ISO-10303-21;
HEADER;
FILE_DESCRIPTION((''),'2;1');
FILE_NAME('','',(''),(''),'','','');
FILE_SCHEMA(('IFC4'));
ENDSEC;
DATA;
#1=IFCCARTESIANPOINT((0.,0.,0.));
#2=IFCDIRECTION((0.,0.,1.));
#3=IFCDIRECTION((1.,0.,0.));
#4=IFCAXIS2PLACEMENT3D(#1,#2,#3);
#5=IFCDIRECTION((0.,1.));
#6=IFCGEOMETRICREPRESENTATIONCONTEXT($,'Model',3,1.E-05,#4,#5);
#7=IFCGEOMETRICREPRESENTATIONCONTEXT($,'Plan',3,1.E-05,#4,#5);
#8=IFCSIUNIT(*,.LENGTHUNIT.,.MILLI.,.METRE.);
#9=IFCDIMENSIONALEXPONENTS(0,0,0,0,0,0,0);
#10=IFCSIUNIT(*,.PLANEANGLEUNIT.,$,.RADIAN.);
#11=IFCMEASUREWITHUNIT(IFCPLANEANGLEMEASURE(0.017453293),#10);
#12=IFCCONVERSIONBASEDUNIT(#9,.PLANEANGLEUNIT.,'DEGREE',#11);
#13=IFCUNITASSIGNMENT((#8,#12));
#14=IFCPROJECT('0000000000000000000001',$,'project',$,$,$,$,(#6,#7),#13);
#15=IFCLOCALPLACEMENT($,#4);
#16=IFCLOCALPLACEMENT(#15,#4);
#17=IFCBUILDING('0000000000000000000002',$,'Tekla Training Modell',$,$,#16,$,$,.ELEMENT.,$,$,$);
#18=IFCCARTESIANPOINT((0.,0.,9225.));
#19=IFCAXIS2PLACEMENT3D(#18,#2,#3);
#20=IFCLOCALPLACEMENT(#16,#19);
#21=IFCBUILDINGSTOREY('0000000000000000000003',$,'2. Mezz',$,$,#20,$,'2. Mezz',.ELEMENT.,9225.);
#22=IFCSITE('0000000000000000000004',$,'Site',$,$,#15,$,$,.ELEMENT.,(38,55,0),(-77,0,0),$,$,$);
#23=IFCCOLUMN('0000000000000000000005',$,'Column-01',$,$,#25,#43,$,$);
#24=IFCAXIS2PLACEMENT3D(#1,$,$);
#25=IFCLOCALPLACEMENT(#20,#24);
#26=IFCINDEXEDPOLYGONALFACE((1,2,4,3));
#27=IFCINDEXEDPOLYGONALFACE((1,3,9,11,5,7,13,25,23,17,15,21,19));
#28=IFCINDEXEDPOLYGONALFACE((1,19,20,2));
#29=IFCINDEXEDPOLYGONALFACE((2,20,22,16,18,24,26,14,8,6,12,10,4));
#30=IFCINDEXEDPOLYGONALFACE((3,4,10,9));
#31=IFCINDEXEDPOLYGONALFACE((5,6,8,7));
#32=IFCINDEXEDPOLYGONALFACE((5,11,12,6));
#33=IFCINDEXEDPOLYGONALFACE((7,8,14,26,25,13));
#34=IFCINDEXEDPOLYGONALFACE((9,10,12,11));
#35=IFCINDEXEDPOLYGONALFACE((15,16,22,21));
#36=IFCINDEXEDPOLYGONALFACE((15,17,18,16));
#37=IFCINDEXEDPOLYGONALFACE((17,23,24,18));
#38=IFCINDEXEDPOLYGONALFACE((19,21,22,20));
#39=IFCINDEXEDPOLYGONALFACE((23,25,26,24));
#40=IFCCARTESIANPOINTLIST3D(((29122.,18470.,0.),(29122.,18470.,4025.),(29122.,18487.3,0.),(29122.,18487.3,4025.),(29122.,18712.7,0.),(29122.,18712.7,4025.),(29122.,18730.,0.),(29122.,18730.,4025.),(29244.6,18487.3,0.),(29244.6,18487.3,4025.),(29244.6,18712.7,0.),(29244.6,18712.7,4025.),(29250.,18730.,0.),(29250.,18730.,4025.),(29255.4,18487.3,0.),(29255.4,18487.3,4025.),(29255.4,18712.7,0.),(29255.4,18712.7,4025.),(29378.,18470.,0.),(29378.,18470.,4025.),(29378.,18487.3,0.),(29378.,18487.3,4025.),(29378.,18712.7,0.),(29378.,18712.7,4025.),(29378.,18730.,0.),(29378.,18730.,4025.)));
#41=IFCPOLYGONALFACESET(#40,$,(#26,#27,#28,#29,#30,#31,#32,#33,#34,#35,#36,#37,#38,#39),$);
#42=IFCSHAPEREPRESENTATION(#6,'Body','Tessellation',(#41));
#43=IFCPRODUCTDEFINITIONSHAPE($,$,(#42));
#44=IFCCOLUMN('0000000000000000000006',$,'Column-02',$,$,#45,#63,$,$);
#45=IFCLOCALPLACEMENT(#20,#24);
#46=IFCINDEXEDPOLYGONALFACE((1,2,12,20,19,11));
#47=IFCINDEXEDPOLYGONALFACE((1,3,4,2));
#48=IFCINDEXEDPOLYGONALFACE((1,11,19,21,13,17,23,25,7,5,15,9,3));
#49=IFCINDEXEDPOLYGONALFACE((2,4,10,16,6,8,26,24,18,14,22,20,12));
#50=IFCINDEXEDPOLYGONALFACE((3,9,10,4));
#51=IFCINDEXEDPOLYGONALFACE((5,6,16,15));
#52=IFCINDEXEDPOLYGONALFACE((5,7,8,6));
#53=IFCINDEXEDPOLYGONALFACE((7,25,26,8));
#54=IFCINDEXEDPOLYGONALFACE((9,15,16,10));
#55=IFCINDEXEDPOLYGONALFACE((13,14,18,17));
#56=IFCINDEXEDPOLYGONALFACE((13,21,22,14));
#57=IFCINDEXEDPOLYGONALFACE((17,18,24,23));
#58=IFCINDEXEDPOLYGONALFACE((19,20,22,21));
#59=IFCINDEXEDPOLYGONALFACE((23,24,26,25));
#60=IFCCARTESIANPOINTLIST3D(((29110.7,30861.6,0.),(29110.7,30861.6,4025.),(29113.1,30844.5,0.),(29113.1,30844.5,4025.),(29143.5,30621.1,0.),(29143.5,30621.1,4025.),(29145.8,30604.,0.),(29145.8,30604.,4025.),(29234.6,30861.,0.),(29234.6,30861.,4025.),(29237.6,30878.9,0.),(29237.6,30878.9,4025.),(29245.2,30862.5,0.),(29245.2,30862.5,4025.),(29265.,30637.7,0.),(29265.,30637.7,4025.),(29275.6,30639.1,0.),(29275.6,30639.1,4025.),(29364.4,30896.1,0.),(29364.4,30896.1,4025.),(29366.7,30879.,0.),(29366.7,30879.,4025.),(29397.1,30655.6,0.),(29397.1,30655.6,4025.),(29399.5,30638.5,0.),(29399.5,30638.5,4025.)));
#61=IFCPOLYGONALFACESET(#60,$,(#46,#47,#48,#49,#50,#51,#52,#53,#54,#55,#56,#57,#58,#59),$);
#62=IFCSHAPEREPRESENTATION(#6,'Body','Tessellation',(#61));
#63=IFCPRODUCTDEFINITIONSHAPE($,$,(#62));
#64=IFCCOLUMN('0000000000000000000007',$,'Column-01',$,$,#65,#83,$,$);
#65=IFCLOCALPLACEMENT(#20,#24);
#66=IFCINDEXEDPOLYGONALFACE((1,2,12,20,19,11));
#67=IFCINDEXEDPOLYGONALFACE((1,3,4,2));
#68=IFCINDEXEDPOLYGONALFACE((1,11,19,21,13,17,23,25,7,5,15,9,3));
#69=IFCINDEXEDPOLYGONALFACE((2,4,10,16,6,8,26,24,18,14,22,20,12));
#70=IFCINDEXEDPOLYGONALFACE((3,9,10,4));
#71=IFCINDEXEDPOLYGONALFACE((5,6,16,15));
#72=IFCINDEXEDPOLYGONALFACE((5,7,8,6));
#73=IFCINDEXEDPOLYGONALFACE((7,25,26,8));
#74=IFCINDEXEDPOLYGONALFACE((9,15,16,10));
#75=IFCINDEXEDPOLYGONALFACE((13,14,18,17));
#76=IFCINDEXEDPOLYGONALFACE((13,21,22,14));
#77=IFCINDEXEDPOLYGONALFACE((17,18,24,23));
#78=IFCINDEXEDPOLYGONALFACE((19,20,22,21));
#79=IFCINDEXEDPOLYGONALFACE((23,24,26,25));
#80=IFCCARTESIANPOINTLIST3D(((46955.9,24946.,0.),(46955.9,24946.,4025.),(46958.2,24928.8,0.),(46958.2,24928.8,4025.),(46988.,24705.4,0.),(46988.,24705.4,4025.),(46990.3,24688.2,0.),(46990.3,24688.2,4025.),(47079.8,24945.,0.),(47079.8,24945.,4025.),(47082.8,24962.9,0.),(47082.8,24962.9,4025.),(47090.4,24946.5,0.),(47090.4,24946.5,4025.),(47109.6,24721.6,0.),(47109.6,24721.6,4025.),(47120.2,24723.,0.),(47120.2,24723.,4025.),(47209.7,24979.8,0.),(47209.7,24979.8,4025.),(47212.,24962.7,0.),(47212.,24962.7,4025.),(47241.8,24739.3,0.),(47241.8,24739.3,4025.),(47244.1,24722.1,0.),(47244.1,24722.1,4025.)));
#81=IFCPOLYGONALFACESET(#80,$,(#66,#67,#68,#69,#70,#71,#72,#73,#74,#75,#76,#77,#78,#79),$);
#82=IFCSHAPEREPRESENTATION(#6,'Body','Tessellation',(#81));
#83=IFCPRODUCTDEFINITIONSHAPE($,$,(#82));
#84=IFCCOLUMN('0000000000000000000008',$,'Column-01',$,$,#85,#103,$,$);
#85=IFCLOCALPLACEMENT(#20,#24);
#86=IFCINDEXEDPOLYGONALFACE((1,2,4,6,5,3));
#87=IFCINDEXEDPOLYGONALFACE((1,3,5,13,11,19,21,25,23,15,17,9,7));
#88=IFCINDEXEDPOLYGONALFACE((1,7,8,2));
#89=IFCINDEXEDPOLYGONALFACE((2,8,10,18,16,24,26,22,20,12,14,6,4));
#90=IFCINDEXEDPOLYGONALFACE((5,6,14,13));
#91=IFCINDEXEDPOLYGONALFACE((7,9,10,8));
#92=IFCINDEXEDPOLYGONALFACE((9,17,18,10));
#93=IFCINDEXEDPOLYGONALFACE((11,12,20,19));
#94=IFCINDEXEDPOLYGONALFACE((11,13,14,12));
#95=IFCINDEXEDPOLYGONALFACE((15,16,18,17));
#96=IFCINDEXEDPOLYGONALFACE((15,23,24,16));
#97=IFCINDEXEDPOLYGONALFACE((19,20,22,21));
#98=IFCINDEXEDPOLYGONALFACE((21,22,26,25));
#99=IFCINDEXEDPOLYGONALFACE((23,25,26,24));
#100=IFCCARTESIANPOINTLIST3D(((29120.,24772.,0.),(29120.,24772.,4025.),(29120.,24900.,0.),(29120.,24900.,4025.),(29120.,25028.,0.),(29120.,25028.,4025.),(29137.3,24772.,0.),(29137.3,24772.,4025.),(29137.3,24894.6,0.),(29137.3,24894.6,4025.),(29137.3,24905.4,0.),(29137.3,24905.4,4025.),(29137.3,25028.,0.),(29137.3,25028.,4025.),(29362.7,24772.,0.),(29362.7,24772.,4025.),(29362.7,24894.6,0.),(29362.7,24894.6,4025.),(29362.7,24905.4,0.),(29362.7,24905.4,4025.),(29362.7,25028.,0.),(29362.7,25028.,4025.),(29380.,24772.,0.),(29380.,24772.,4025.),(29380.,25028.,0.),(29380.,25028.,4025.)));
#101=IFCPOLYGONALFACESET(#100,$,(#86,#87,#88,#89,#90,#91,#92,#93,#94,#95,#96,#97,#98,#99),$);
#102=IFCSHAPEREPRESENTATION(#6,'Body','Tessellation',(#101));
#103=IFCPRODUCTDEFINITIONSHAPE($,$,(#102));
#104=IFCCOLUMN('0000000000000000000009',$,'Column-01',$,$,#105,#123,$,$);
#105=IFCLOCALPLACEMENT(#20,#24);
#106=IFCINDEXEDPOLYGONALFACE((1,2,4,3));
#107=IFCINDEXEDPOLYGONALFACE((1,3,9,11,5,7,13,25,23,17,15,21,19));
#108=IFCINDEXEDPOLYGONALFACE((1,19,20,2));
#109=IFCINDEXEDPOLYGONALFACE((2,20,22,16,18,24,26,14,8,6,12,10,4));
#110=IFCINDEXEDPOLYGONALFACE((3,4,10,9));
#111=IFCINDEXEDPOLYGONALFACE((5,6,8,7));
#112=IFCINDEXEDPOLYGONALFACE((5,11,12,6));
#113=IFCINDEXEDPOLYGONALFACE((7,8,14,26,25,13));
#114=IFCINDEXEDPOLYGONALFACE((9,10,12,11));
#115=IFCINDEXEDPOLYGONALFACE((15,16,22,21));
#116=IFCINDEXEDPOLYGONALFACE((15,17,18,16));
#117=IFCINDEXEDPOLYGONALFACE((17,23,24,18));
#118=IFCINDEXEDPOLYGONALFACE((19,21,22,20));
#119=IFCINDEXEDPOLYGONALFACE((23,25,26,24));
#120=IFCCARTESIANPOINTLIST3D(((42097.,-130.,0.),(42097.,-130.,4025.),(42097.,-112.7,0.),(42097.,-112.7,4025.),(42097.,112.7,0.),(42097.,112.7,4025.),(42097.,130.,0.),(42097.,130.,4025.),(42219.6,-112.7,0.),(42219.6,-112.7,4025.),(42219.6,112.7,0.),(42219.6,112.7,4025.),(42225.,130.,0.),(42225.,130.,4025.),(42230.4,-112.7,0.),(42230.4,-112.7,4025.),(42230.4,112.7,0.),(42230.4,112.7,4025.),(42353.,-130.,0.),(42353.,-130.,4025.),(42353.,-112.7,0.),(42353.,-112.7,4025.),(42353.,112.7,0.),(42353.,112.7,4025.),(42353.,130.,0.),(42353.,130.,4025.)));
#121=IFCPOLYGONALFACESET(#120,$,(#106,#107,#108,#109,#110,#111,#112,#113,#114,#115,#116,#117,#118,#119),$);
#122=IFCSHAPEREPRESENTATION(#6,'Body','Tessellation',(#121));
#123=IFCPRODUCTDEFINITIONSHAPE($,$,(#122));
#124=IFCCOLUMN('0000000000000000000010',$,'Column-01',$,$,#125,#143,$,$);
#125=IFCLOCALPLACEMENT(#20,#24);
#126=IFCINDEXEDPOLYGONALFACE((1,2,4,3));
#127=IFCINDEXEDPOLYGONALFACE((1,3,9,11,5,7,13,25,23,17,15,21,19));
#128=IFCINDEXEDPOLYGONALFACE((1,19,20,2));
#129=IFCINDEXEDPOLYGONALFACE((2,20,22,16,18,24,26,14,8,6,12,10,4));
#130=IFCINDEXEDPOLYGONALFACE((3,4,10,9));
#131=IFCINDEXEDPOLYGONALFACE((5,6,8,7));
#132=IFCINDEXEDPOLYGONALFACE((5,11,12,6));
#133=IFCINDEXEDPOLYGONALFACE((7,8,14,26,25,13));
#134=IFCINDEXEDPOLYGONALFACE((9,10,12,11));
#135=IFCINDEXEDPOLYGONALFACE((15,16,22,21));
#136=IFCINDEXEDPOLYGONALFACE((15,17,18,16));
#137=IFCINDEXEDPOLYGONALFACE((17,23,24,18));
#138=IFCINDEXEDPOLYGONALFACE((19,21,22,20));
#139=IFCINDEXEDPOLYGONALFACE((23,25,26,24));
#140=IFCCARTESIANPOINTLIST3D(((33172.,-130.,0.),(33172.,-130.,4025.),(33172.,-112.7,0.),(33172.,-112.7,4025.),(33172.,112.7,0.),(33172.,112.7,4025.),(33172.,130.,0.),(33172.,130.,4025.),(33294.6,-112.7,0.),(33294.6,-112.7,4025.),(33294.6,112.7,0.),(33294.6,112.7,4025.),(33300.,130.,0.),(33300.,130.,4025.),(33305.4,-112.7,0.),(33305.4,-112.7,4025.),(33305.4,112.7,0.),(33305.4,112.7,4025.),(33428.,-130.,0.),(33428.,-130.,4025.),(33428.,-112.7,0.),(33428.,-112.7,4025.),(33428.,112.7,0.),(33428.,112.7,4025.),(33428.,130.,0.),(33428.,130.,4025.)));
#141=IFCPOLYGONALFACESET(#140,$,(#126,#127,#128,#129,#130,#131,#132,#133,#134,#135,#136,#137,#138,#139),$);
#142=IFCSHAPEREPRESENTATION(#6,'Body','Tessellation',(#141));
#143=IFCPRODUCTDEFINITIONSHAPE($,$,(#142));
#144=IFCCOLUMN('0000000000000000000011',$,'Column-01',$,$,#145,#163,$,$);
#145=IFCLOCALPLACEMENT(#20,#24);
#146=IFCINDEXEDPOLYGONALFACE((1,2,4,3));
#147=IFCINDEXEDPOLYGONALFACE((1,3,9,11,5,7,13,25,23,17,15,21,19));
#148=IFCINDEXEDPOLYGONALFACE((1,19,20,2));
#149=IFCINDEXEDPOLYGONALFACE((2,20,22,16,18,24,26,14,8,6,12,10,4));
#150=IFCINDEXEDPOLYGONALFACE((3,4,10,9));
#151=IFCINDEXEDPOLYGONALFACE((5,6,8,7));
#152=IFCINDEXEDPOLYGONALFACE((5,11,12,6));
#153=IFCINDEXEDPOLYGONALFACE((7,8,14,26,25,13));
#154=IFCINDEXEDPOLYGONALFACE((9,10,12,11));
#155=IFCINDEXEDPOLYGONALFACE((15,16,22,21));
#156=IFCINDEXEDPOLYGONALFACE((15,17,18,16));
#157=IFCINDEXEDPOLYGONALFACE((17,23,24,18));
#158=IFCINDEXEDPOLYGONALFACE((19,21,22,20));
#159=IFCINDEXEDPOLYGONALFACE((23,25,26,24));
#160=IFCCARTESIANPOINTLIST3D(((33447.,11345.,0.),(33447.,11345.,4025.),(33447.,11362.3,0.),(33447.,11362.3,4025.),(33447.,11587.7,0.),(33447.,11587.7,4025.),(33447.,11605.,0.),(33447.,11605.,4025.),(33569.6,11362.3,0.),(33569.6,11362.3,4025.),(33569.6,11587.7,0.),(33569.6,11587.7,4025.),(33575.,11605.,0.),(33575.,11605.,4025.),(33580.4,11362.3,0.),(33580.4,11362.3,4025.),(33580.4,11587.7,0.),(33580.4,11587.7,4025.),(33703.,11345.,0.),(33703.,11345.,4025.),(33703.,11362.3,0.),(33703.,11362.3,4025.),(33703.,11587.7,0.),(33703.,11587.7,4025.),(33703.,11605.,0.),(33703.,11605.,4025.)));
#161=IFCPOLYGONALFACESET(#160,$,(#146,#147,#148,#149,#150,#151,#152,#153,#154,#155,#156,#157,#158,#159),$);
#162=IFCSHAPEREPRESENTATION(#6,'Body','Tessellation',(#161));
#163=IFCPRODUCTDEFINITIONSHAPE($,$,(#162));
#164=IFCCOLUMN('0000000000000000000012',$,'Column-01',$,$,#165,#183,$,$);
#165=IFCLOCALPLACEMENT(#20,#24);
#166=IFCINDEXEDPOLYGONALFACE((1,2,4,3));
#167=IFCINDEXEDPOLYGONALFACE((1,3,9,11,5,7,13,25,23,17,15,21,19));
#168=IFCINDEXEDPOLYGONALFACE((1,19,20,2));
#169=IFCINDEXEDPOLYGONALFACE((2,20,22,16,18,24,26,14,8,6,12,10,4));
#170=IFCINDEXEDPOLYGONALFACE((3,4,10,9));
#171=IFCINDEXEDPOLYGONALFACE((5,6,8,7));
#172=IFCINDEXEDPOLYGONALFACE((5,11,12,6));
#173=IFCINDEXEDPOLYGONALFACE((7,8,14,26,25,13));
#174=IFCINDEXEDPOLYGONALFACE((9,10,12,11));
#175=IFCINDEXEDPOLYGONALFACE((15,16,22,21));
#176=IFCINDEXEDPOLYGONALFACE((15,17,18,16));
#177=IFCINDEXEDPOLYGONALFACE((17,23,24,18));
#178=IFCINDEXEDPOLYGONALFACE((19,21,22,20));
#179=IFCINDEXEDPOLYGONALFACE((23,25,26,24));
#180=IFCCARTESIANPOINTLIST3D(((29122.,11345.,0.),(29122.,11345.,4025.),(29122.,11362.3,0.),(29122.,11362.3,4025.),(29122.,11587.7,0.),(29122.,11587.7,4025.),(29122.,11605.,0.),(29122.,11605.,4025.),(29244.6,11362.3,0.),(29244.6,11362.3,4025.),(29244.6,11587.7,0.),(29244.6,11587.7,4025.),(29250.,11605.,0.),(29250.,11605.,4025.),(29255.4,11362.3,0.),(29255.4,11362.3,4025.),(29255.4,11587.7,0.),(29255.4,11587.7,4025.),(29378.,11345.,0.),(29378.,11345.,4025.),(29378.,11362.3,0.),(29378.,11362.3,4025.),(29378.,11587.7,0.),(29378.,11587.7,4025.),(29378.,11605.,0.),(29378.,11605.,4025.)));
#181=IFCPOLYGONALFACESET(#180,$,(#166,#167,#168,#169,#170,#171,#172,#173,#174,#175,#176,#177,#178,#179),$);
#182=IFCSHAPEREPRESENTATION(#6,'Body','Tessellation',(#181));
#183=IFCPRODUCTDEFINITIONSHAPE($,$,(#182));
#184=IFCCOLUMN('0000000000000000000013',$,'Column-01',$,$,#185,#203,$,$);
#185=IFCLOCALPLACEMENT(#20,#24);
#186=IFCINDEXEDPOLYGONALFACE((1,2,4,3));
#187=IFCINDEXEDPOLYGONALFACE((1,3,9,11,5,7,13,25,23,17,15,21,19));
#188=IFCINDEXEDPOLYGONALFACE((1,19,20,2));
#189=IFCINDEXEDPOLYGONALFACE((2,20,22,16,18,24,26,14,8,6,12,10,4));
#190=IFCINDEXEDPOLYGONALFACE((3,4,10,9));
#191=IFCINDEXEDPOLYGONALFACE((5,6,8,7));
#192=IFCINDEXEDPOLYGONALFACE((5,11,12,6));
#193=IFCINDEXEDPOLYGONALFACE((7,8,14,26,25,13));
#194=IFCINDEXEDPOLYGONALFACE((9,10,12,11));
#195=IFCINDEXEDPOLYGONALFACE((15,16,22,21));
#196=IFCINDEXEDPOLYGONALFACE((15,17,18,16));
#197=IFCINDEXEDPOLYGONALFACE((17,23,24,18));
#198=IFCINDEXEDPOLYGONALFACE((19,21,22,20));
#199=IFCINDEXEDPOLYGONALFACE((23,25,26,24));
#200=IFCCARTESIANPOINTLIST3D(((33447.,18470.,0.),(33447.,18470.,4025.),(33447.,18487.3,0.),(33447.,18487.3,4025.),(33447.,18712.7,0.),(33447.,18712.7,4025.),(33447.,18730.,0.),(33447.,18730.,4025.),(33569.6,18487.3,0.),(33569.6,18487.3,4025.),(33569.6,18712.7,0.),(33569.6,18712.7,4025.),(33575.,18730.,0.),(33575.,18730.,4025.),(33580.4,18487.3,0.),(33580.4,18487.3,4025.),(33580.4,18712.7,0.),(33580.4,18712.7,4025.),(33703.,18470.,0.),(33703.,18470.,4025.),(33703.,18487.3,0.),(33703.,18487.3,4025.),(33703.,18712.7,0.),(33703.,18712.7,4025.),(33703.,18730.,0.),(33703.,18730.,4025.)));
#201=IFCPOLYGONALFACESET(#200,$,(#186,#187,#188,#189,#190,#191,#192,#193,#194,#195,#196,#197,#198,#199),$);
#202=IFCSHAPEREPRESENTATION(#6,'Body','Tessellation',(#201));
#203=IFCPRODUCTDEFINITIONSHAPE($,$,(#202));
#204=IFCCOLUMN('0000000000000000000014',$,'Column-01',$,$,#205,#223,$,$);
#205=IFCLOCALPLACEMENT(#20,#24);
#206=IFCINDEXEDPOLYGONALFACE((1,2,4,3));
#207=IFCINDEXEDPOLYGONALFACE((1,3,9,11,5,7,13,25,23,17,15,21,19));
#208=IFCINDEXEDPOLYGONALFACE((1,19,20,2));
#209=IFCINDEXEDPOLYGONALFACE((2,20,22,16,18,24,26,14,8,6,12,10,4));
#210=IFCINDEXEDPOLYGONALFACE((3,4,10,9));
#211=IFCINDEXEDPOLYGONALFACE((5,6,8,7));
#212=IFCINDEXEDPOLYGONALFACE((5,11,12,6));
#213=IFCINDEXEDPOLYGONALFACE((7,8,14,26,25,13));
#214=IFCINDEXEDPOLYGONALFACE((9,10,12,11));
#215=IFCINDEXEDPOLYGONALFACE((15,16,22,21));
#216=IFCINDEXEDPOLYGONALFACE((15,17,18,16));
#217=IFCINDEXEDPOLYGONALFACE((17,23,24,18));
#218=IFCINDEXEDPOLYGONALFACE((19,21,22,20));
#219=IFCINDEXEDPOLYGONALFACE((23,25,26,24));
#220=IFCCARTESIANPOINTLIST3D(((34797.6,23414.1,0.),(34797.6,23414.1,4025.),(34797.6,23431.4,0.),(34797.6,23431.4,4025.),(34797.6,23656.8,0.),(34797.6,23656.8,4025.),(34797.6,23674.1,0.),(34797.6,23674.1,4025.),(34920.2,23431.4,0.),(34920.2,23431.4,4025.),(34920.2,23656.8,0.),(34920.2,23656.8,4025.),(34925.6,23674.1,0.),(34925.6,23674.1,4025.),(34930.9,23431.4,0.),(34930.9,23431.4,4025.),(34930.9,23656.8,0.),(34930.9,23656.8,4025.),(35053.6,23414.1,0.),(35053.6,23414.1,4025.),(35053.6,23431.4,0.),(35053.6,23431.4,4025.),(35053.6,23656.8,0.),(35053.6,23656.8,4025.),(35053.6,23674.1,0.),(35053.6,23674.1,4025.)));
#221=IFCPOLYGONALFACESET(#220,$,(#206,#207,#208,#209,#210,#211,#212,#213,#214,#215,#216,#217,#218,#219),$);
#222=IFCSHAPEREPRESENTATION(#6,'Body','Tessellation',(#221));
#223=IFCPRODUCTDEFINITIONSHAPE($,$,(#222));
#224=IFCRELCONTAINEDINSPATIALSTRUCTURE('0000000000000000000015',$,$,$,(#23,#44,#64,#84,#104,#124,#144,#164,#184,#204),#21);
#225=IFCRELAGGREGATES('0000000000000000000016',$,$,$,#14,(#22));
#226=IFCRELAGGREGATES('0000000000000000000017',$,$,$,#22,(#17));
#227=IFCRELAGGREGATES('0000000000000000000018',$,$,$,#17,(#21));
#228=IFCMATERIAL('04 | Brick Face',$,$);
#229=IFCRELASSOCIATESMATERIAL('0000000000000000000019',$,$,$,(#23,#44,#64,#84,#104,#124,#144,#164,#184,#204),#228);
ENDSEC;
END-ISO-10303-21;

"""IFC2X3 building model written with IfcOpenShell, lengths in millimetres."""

from ifc_helpers import new_model, entity, si_unit, converted_unit, direction, frame, origin_with_axes, place, context, project, spatial, polyline, outline, extrude, material, element, save


model = new_model("IFC2X3")

# Units and contexts
model_context = context("Model", 3, precision=1e-05, world=origin_with_axes(), true_north=direction((0.0, 1.0)))
plan_context = context("Plan", 3, precision=1e-05, world=origin_with_axes(), true_north=direction((0.0, 1.0)))
ifc_project = project(units=[si_unit("LENGTHUNIT", "METRE", prefix="MILLI"), converted_unit("PLANEANGLEUNIT", "DEGREE", entity("IfcPlaneAngleMeasure", 0.017453293), si_unit("PLANEANGLEUNIT", "RADIAN"), dimensions=[0, 0, 0, 0, 0, 0, 0])], contexts=[model_context, plan_context])

# Site, building, storey
site_placement = place(None, origin_with_axes())
site = spatial("IfcSite", under=ifc_project, at=site_placement, Name="Site", CompositionType="ELEMENT", RefLatitude=(38, 55, 0), RefLongitude=(-77, 0, 0))
building_placement = place(site_placement, origin_with_axes())
building = spatial("IfcBuilding", under=site, at=building_placement, Name="Tekla Training Modell", CompositionType="ELEMENT")
storey_placement = place(building_placement, frame((0.0, 0.0, 9225.0), z_axis=(0.0, 0.0, 1.0), x_axis=(1.0, 0.0, 0.0)))
storey = spatial("IfcBuildingStorey", under=building, at=storey_placement, Name="2. Mezz", LongName="2. Mezz", CompositionType="ELEMENT", Elevation=9225.0)

# Columns
ifc_material_1 = material(Name="04 | Brick Face")
for number, where, z_axis, x_axis, name in (
    (1, (29250.0, 18600.0, 0.0), (0.0, 0.0, 1.0), (1.0, 0.0, 0.0), "Column-01"),
    (2, (29255.1, 30750.1, 0.0), (0.0, 0.0, 1.0), (0.990872, 0.134803, 0.0), "Column-02"),
    (3, (47100.0, 24834.0, 0.0), (0.0, 0.0, 1.0), (0.991216, 0.132256, 0.0), "Column-01"),
    (4, (29250.0, 24900.0, 0.0), (0.0, 0.0, 1.0), (0.0, 1.0, 0.0), "Column-01"),
    (5, (42225.0, 0.0, 0.0), (0.0, 0.0, 1.0), (1.0, 0.0, 0.0), "Column-01"),
    (6, (33300.0, 0.0, 0.0), (0.0, 0.0, 1.0), (1.0, 0.0, 0.0), "Column-01"),
    (7, (33575.0, 11475.0, 0.0), (0.0, 0.0, 1.0), (1.0, 0.0, 0.0), "Column-01"),
    (8, (29250.0, 11475.0, 0.0), (0.0, 0.0, 1.0), (1.0, 0.0, 0.0), "Column-01"),
    (9, (33575.0, 18600.0, 0.0), (0.0, 0.0, 1.0), (1.0, 0.0, 0.0), "Column-01"),
    (10, (34925.6, 23544.1, 0.0), (0.0, 0.0, 1.0), (1.0, 0.0, 0.0), "Column-01"),
):
    element("IfcColumn", number, at=place(storey_placement, frame(where, z_axis=z_axis, x_axis=x_axis)), inside=storey, material=ifc_material_1, Name=name, context=model_context, shape_type="SweptSolid", body=[
        extrude(outline(polyline([(0.0, 130.0), (-128.0, 130.0), (-128.0, 112.7), (-5.3, 112.7), (-5.3, -112.7), (-128.0, -112.7), (-128.0, -130.0), (128.0, -130.0), (128.0, -112.7), (5.3, -112.7), (5.3, 112.7), (128.0, 112.7), (128.0, 130.0), (0.0, 130.0)])), origin_with_axes(), (0.0, 0.0, 1.0), 4025.0),
    ])

save(model, "model.ifc")
